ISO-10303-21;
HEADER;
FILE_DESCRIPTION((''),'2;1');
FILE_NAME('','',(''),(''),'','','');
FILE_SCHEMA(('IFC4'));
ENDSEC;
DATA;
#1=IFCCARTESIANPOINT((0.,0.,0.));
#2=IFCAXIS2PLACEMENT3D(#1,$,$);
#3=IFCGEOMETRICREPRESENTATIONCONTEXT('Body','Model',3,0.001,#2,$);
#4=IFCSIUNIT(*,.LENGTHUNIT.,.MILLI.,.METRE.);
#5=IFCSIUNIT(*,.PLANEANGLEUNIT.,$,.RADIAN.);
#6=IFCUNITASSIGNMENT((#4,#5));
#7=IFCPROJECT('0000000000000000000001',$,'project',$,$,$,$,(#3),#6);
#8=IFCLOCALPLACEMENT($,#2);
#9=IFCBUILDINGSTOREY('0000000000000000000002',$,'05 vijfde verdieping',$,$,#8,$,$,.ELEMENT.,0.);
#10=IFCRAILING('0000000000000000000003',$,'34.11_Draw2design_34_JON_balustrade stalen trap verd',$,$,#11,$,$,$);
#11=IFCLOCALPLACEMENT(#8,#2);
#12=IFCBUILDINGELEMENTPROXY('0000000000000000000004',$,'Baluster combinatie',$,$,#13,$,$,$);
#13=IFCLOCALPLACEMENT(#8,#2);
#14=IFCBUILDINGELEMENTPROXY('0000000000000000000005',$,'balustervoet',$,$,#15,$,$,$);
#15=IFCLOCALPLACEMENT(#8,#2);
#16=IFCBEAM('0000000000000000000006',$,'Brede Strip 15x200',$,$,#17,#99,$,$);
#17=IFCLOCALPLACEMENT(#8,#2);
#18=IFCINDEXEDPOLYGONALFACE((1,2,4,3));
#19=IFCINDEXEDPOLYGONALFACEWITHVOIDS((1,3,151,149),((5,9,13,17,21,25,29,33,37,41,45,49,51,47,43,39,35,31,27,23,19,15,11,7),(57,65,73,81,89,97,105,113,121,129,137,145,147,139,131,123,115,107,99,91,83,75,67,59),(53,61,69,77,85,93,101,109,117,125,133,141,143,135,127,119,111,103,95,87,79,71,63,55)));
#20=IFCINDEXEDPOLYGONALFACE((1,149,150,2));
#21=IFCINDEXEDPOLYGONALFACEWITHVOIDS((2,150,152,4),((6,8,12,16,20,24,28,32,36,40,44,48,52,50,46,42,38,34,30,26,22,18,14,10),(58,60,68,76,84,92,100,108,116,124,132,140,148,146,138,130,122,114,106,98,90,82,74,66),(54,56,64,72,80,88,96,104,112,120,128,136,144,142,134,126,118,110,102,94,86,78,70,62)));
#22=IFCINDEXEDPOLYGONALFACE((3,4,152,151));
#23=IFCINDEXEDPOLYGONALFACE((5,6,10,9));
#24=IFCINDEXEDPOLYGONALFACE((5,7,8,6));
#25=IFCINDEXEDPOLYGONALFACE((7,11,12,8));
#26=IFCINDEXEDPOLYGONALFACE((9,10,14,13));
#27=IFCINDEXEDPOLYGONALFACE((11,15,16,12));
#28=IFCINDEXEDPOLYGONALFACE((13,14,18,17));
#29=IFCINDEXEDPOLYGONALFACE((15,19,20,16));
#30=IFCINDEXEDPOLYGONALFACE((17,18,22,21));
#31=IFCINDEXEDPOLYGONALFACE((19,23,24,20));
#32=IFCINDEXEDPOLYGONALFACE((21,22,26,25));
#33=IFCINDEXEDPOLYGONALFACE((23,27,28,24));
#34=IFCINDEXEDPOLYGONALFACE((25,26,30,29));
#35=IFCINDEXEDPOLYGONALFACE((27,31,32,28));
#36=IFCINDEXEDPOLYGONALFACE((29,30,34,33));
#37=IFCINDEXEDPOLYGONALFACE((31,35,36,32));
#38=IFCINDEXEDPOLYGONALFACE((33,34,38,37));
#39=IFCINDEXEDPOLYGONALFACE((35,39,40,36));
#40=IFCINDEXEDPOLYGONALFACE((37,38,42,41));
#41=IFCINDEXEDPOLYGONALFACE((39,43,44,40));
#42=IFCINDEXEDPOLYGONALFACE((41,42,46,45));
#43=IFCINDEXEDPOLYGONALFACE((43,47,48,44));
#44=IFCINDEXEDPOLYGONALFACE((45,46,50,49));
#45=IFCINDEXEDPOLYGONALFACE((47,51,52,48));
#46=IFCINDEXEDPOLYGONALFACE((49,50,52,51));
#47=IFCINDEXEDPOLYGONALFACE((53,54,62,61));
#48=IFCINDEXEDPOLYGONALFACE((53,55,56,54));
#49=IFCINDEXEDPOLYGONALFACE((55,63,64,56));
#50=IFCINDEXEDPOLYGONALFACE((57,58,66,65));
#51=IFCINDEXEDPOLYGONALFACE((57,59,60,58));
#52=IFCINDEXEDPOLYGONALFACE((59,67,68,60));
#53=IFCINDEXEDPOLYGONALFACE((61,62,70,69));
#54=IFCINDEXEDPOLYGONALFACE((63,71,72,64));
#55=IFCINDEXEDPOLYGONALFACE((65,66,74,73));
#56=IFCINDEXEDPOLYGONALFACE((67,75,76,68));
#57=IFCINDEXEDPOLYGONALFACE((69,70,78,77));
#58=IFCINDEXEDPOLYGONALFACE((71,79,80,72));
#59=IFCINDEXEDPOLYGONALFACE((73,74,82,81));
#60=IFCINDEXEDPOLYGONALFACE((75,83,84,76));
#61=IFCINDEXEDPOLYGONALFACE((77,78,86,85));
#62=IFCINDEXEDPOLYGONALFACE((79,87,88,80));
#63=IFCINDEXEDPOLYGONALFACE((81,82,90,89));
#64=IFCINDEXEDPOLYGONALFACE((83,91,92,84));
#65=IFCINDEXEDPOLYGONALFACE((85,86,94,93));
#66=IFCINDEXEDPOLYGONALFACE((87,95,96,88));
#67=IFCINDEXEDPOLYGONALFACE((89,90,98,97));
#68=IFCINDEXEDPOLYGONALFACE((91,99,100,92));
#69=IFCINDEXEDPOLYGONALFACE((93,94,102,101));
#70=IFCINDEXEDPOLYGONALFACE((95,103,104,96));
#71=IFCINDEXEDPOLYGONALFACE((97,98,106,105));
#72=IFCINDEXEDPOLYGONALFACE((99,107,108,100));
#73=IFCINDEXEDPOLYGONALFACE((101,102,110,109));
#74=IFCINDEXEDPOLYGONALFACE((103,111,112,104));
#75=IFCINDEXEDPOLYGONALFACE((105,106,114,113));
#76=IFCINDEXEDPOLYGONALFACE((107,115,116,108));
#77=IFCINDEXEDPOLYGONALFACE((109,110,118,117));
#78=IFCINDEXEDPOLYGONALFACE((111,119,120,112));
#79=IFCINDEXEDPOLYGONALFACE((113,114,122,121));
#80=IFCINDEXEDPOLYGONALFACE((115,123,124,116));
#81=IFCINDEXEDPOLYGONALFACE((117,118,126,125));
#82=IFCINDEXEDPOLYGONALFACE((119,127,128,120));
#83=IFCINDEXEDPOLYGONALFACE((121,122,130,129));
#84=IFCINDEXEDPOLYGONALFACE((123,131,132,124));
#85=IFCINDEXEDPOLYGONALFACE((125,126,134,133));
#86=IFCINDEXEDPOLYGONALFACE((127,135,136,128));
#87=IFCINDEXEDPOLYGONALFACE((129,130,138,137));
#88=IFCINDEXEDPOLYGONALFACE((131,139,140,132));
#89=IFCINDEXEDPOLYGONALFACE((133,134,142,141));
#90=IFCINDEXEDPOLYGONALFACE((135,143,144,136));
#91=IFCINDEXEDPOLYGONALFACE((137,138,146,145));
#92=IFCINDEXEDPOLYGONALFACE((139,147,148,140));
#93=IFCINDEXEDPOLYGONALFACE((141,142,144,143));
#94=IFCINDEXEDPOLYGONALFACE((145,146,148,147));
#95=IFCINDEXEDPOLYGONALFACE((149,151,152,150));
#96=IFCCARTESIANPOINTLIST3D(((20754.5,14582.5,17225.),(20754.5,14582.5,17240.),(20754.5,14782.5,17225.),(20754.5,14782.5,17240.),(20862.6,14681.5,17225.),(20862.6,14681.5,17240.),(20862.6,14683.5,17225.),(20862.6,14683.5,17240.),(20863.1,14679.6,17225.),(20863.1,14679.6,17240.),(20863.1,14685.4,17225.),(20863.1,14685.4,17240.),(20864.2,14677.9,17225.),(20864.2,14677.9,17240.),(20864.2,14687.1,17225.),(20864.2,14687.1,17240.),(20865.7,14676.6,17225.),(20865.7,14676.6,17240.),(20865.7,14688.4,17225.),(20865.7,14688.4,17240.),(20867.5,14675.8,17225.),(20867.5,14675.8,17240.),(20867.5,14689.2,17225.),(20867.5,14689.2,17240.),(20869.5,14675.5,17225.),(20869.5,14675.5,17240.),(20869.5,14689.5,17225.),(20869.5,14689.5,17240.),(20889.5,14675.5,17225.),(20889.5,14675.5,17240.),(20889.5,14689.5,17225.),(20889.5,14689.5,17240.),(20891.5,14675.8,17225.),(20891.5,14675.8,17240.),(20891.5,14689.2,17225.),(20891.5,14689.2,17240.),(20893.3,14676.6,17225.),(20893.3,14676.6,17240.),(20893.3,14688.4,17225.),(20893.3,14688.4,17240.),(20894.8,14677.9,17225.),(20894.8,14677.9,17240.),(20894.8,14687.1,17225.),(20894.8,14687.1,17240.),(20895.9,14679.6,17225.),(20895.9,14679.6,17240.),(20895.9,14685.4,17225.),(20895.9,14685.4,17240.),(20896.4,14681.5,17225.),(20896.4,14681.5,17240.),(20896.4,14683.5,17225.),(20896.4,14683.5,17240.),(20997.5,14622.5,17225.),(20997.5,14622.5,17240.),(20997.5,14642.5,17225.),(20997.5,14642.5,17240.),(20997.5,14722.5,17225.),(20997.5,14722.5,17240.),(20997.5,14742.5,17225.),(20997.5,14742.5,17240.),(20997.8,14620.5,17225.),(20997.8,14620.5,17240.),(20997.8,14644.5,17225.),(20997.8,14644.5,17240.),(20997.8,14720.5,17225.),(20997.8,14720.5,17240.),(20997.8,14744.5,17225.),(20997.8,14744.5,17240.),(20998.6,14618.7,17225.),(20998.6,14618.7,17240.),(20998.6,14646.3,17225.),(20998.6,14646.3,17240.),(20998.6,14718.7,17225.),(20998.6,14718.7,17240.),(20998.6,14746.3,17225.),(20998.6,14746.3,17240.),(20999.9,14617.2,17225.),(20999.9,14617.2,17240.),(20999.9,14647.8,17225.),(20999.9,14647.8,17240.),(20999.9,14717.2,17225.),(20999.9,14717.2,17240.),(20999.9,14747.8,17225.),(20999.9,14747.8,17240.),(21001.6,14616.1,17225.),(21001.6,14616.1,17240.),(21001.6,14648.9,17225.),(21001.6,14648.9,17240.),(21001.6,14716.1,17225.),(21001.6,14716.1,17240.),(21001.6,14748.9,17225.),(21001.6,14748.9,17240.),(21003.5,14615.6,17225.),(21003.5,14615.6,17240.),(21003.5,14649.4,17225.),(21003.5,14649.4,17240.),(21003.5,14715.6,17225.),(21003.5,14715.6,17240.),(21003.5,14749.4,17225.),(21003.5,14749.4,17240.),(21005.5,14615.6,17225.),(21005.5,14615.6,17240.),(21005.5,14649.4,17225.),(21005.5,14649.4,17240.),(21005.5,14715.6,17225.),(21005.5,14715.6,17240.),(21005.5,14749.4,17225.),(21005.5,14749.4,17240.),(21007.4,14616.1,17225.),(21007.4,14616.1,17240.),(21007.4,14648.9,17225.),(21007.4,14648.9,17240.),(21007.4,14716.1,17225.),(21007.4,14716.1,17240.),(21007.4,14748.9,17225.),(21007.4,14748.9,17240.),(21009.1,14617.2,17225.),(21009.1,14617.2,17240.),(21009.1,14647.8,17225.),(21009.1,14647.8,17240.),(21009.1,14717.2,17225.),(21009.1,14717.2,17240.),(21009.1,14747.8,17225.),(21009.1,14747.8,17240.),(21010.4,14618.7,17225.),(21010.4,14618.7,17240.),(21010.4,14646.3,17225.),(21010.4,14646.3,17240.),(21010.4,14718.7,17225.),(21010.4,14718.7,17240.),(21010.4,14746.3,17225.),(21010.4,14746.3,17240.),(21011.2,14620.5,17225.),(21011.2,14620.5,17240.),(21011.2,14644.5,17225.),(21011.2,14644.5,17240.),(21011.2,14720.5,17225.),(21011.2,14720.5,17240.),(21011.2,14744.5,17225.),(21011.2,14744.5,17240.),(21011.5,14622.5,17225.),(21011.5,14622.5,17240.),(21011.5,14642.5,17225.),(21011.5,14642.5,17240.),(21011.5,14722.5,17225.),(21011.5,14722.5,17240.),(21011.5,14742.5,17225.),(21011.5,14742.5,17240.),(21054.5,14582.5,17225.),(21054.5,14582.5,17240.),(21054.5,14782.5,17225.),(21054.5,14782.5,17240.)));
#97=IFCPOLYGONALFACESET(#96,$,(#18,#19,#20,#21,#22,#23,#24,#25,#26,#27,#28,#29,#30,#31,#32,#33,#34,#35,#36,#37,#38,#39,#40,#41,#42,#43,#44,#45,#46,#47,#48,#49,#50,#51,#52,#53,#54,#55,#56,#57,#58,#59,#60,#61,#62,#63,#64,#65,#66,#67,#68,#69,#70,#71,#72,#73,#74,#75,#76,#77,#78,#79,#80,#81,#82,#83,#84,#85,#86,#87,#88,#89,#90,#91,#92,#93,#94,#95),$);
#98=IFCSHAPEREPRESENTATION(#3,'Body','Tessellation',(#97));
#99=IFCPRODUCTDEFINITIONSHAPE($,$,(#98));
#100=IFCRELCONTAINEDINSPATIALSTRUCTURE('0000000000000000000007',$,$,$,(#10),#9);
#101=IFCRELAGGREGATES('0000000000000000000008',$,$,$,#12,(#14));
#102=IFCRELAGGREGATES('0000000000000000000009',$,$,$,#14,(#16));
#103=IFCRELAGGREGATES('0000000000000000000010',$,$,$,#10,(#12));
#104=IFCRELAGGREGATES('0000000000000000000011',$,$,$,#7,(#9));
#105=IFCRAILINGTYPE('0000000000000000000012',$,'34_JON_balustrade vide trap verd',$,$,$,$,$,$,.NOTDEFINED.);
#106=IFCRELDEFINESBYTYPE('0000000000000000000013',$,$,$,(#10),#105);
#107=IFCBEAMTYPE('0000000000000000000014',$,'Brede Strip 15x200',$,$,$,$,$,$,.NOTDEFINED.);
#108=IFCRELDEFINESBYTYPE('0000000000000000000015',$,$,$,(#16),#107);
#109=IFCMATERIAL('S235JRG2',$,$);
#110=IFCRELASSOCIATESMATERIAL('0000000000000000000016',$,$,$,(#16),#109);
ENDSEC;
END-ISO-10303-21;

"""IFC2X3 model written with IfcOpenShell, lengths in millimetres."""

from ifc_helpers import new_model, si_unit, point, frame, frame_2d, origin, origin_2d, place, context, project, spatial, circle_curve, line_curve, trimmed, segment, composite_curve, rectangle, outline, extrude, source, transform, mapped, material, type_object, element, aggregate, save


model = new_model("IFC2X3")

# Units and contexts
model_context = context("Model", 3, precision=0.001, world=origin(), identifier="Body")
ifc_project = project(units=[si_unit("LENGTHUNIT", "METRE", prefix="MILLI"), si_unit("PLANEANGLEUNIT", "RADIAN")], contexts=[model_context])

# Storey
storey_placement = place(None, origin())
storey = spatial("IfcBuildingStorey", under=ifc_project, at=storey_placement, Name="05 vijfde verdieping", CompositionType="ELEMENT", Elevation=0.0)

# Shared definitions
ifc_material_1 = material(Name="S235JRG2")

# Railing, building element proxies, beam, openings
railing_type = type_object("IfcRailingType", Name="34_JON_balustrade vide trap verd")
railing_placement = place(storey_placement, frame((-1939.6, -29817.1, 71583.6)))
railing = element("IfcRailing", 1, at=railing_placement, inside=storey, type_object=railing_type, Name="34.11_Draw2design_34_JON_balustrade stalen trap verd")
proxy_1_placement = place(railing_placement, frame((22994.2, 44834.6, -54348.6), z_axis=(0.0, 0.0, 1.0), x_axis=(0.0, 1.0, 0.0)))
proxy_1 = element("IfcBuildingElementProxy", 2, at=proxy_1_placement, Name="Baluster combinatie")
proxy_2_placement = place(proxy_1_placement, frame((-45247.5, 21054.5, -49235.0), z_axis=(0.0, 0.0, 1.0), x_axis=(0.0, -1.0, 0.0)))
proxy_2 = element("IfcBuildingElementProxy", 3, at=proxy_2_placement, Name="balustervoet")
aggregate(proxy_1, [proxy_2])
beam_type_1 = type_object("IfcBeamType", Name="Brede Strip 15x200")
shared_shape_1 = source(origin(), model_context, "Body", "SweptSolid", [
    extrude(rectangle(XDim=15.0, YDim=200.0, at=origin_2d()), origin(), (0.0, 0.0, -1.0), 300.0),
])
beam_1_placement = place(proxy_2_placement, frame((21054.5, 44912.5, 49232.5), z_axis=(1.0, 0.0, 0.0), x_axis=(0.0, 0.0, 1.0)))
beam_1 = element("IfcBeam", 4, at=beam_1_placement, type_object=beam_type_1, material=ifc_material_1, Name="Brede Strip 15x200", context=model_context, shape_type="MappedRepresentation", body=[
    mapped(shared_shape_1, transform((0.0, 0.0, 0.0), scale=1.0)),
])
opening_1_placement = place(beam_1_placement, frame((7.5, 0.0, -175.0), z_axis=(-1.0, 0.0, 0.0), x_axis=(0.0, 0.0, -1.0)))
element("IfcOpeningElement", 5, at=opening_1_placement, cuts=beam_1, ObjectType="Opening", context=model_context, shape_type="SweptSolid", body=[
    extrude(outline(composite_curve([segment(trimmed(circle_curve(frame_2d((10.0, 0.0), x_axis=(0.0, -1.0)), 7.0), [point((10.0, 7.0))], [point((10.0, -7.0))], False, "CARTESIAN"), True, "CONTINUOUS"), segment(trimmed(line_curve((10.0, -7.0), (-20.0, 0.0), 20.0), [point((10.0, -7.0))], [point((-10.0, -7.0))], True, "CARTESIAN"), True, "CONTINUOUS"), segment(trimmed(circle_curve(frame_2d((-10.0, 0.0), x_axis=(0.0, -1.0)), 7.0), [point((-10.0, -7.0))], [point((-10.0, 7.0))], False, "CARTESIAN"), True, "CONTINUOUS"), segment(trimmed(line_curve((-10.0, 7.0), (20.0, 0.0), 20.0), [point((-10.0, 7.0))], [point((10.0, 7.0))], True, "CARTESIAN"), True, "CONTINUOUS")], self_intersect=False)), origin(), (0.0, 0.0, 1.0), 15.0),
])
opening_2_placement = place(beam_1_placement, frame((7.5, -50.0, -50.0), z_axis=(-1.0, 0.0, 0.0), x_axis=(0.0, -1.0, 0.0)))
element("IfcOpeningElement", 6, at=opening_2_placement, cuts=beam_1, ObjectType="Opening", context=model_context, shape_type="SweptSolid", body=[
    extrude(outline(composite_curve([segment(trimmed(circle_curve(frame_2d((10.0, 0.0), x_axis=(0.0, -1.0)), 7.0), [point((10.0, 7.0))], [point((10.0, -7.0))], False, "CARTESIAN"), True, "CONTINUOUS"), segment(trimmed(line_curve((10.0, -7.0), (-20.0, 0.0), 20.0), [point((10.0, -7.0))], [point((-10.0, -7.0))], True, "CARTESIAN"), True, "CONTINUOUS"), segment(trimmed(circle_curve(frame_2d((-10.0, 0.0), x_axis=(0.0, -1.0)), 7.0), [point((-10.0, -7.0))], [point((-10.0, 7.0))], False, "CARTESIAN"), True, "CONTINUOUS"), segment(trimmed(line_curve((-10.0, 7.0), (20.0, 0.0), 20.0), [point((-10.0, 7.0))], [point((10.0, 7.0))], True, "CARTESIAN"), True, "CONTINUOUS")], self_intersect=False)), origin(), (0.0, 0.0, 1.0), 15.0),
])
opening_3_placement = place(beam_1_placement, frame((7.5, 50.0, -50.0), z_axis=(-1.0, 0.0, 0.0), x_axis=(0.0, -1.0, 0.0)))
element("IfcOpeningElement", 7, at=opening_3_placement, cuts=beam_1, ObjectType="Opening", context=model_context, shape_type="SweptSolid", body=[
    extrude(outline(composite_curve([segment(trimmed(circle_curve(frame_2d((10.0, 0.0), x_axis=(0.0, -1.0)), 7.0), [point((10.0, 7.0))], [point((10.0, -7.0))], False, "CARTESIAN"), True, "CONTINUOUS"), segment(trimmed(line_curve((10.0, -7.0), (-20.0, 0.0), 20.0), [point((10.0, -7.0))], [point((-10.0, -7.0))], True, "CARTESIAN"), True, "CONTINUOUS"), segment(trimmed(circle_curve(frame_2d((-10.0, 0.0), x_axis=(0.0, -1.0)), 7.0), [point((-10.0, -7.0))], [point((-10.0, 7.0))], False, "CARTESIAN"), True, "CONTINUOUS"), segment(trimmed(line_curve((-10.0, 7.0), (20.0, 0.0), 20.0), [point((-10.0, 7.0))], [point((10.0, 7.0))], True, "CARTESIAN"), True, "CONTINUOUS")], self_intersect=False)), origin(), (0.0, 0.0, 1.0), 15.0),
])
aggregate(proxy_2, [beam_1])
aggregate(railing, [proxy_1])

save(model, "model.ifc")
